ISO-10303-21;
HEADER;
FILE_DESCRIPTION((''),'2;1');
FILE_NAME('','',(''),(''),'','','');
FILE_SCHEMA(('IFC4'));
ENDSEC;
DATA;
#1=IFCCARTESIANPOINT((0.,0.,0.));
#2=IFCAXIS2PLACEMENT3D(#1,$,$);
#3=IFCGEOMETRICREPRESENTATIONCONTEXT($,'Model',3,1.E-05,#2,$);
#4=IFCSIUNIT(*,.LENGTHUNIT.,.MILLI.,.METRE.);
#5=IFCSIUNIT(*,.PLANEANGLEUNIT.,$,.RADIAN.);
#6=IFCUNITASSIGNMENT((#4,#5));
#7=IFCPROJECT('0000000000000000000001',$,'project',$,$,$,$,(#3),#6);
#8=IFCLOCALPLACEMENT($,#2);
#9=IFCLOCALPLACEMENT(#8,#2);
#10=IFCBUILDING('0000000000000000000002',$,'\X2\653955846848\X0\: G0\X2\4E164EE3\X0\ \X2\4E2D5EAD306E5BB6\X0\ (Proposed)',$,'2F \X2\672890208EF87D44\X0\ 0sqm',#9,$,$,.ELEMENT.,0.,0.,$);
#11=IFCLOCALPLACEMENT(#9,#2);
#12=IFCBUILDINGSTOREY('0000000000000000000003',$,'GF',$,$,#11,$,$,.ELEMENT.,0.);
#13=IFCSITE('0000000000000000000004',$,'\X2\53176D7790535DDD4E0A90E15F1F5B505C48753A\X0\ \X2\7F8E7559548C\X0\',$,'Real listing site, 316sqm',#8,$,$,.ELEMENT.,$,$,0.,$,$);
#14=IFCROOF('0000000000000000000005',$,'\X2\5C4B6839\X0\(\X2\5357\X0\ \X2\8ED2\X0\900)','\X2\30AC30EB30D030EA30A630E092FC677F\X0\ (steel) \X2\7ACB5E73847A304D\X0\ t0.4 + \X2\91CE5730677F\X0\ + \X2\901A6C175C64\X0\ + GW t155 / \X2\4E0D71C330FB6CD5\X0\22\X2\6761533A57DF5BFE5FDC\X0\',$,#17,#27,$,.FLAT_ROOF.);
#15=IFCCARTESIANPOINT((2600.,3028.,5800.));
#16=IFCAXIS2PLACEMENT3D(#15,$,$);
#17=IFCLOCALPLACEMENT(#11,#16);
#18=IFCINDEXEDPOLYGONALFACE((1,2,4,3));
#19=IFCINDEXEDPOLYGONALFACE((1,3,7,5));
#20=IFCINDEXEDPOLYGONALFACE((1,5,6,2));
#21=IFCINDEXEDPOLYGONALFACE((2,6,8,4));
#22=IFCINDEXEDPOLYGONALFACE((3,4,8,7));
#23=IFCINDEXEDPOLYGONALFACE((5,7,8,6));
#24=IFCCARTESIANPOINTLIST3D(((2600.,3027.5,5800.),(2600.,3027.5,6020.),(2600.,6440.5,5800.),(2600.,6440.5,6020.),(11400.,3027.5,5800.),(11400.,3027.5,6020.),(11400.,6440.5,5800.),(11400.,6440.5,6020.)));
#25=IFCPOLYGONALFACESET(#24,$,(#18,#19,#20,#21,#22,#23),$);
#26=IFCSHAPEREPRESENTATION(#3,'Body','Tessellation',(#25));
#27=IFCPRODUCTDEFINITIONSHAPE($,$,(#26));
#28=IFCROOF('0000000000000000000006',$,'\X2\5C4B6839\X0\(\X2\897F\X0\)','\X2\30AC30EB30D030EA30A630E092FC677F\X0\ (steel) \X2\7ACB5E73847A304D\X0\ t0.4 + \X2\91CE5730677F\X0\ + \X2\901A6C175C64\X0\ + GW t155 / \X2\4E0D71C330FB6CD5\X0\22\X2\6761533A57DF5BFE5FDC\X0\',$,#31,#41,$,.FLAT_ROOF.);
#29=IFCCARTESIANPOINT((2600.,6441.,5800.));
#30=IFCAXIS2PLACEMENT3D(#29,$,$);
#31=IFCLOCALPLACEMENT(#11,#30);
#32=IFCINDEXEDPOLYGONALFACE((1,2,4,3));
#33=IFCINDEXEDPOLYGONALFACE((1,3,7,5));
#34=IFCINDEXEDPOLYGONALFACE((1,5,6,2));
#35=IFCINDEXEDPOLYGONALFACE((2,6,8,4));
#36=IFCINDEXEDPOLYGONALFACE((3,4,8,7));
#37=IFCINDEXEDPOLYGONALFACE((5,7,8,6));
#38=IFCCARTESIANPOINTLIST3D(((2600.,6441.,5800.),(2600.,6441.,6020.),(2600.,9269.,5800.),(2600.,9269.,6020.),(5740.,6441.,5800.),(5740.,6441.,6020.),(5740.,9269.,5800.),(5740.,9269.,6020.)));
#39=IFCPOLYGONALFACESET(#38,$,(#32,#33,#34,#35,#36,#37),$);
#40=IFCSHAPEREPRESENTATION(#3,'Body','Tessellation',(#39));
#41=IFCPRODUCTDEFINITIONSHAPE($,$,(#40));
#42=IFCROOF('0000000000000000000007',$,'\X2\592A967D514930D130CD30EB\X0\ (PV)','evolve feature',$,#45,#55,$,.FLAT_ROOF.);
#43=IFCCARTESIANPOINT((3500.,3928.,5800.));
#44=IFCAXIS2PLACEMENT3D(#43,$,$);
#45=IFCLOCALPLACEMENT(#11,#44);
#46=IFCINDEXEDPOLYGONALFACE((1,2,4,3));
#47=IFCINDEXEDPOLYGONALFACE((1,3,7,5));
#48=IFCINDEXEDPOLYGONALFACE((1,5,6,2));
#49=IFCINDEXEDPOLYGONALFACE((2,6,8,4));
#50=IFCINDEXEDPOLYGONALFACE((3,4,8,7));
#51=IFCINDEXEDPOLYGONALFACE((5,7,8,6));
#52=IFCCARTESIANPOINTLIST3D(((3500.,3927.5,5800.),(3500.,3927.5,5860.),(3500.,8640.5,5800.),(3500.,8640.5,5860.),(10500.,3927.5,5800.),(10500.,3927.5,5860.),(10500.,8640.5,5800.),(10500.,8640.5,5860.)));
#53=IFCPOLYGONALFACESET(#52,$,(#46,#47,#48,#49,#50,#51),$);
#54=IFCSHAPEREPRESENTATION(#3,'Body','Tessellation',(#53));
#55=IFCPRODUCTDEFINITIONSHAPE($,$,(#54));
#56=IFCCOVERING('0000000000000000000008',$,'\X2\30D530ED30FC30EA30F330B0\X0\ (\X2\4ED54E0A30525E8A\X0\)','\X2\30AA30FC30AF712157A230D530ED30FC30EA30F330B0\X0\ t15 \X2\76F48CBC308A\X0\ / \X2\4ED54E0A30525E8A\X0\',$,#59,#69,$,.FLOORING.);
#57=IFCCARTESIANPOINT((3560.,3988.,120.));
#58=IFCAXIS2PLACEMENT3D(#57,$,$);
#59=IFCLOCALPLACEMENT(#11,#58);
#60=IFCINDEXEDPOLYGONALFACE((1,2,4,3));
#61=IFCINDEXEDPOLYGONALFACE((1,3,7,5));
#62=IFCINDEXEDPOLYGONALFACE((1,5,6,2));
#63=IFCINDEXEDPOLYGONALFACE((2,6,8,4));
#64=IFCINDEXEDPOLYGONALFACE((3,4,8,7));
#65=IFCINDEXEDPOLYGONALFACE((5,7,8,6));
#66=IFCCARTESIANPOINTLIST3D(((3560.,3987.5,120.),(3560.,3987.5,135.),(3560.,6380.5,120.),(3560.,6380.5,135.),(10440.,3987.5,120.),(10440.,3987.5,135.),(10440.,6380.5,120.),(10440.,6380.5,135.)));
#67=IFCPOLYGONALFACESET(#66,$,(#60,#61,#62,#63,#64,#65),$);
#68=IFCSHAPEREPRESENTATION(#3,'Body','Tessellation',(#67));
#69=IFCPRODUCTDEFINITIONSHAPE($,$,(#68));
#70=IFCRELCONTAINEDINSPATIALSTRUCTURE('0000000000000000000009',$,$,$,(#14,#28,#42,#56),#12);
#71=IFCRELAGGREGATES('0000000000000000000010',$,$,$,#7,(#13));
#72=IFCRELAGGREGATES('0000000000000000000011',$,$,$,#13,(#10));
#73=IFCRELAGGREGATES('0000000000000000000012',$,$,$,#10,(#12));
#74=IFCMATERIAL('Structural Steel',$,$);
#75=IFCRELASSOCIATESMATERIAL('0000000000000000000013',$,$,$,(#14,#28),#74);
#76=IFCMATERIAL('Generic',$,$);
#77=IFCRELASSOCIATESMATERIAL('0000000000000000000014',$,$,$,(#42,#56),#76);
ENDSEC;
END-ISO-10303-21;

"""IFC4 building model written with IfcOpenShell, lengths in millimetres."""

from ifc_helpers import new_model, si_unit, frame, frame_2d, origin, place, context, project, spatial, rectangle, extrude, material, element, save


model = new_model("IFC4")

# Units and contexts
model_context = context("Model", 3, precision=1e-05, world=origin())
ifc_project = project(units=[si_unit("LENGTHUNIT", "METRE", prefix="MILLI"), si_unit("PLANEANGLEUNIT", "RADIAN")], contexts=[model_context])

# Site, building, storey
site_placement = place(None, origin())
site = spatial("IfcSite", under=ifc_project, at=site_placement, Name="北海道川上郡弟子屈町 美留和", ObjectType="Real listing site, 316sqm", CompositionType="ELEMENT", RefElevation=0.0)
building_placement = place(site_placement, origin())
building = spatial("IfcBuilding", under=site, at=building_placement, Name="改善案: G0世代 中庭の家 (Proposed)", ObjectType="2F 木造軸組 0sqm", CompositionType="ELEMENT", ElevationOfRefHeight=0.0, ElevationOfTerrain=0.0)
storey_placement = place(building_placement, origin())
storey = spatial("IfcBuildingStorey", under=building, at=storey_placement, Name="GF", CompositionType="ELEMENT", Elevation=0.0)

# Shared definitions
ifc_material_1 = material(Name="Generic")

# Roofs
ifc_material_2 = material(Name="Structural Steel")
roof_1_placement = place(storey_placement, frame((2600.0, 3028.0, 5800.0)))
element("IfcRoof", 1, at=roof_1_placement, inside=storey, material=ifc_material_2, Name="屋根(南 軒900)", Description="ガルバリウム鋼板 (steel) 立平葺き t0.4 + 野地板 + 通気層 + GW t155 / 不燃・法22条区域対応", PredefinedType="FLAT_ROOF", context=model_context, shape_type="SweptSolid", body=[
    extrude(rectangle(XDim=8800.0, YDim=3413.0, at=frame_2d((4400.0, 1706.0))), frame((2600.0, 3028.0, 5800.0)), (0.0, 0.0, 1.0), 220.0),
])
roof_2_placement = place(storey_placement, frame((2600.0, 6441.0, 5800.0)))
element("IfcRoof", 2, at=roof_2_placement, inside=storey, material=ifc_material_2, Name="屋根(西)", Description="ガルバリウム鋼板 (steel) 立平葺き t0.4 + 野地板 + 通気層 + GW t155 / 不燃・法22条区域対応", PredefinedType="FLAT_ROOF", context=model_context, shape_type="SweptSolid", body=[
    extrude(rectangle(XDim=3140.0, YDim=2828.0, at=frame_2d((1570.0, 1414.0))), frame((2600.0, 6441.0, 5800.0)), (0.0, 0.0, 1.0), 220.0),
])
roof_3_placement = place(storey_placement, frame((3500.0, 3928.0, 5800.0)))
element("IfcRoof", 3, at=roof_3_placement, inside=storey, material=ifc_material_1, Name="太陽光パネル (PV)", Description="evolve feature", PredefinedType="FLAT_ROOF", context=model_context, shape_type="SweptSolid", body=[
    extrude(rectangle(XDim=7000.0, YDim=4713.0, at=frame_2d((3500.0, 2356.0))), frame((3500.0, 3928.0, 5800.0)), (0.0, 0.0, 1.0), 60.0),
])

# Covering
covering_placement = place(storey_placement, frame((3560.0, 3988.0, 120.0)))
element("IfcCovering", 4, at=covering_placement, inside=storey, material=ifc_material_1, Name="フローリング (仕上げ床)", Description="オーク無垢フローリング t15 直貼り / 仕上げ床", PredefinedType="FLOORING", context=model_context, shape_type="SweptSolid", body=[
    extrude(rectangle(XDim=6880.0, YDim=2393.0, at=frame_2d((3440.0, 1196.0))), frame((3560.0, 3988.0, 120.0)), (0.0, 0.0, 1.0), 15.0),
])

save(model, "model.ifc")
